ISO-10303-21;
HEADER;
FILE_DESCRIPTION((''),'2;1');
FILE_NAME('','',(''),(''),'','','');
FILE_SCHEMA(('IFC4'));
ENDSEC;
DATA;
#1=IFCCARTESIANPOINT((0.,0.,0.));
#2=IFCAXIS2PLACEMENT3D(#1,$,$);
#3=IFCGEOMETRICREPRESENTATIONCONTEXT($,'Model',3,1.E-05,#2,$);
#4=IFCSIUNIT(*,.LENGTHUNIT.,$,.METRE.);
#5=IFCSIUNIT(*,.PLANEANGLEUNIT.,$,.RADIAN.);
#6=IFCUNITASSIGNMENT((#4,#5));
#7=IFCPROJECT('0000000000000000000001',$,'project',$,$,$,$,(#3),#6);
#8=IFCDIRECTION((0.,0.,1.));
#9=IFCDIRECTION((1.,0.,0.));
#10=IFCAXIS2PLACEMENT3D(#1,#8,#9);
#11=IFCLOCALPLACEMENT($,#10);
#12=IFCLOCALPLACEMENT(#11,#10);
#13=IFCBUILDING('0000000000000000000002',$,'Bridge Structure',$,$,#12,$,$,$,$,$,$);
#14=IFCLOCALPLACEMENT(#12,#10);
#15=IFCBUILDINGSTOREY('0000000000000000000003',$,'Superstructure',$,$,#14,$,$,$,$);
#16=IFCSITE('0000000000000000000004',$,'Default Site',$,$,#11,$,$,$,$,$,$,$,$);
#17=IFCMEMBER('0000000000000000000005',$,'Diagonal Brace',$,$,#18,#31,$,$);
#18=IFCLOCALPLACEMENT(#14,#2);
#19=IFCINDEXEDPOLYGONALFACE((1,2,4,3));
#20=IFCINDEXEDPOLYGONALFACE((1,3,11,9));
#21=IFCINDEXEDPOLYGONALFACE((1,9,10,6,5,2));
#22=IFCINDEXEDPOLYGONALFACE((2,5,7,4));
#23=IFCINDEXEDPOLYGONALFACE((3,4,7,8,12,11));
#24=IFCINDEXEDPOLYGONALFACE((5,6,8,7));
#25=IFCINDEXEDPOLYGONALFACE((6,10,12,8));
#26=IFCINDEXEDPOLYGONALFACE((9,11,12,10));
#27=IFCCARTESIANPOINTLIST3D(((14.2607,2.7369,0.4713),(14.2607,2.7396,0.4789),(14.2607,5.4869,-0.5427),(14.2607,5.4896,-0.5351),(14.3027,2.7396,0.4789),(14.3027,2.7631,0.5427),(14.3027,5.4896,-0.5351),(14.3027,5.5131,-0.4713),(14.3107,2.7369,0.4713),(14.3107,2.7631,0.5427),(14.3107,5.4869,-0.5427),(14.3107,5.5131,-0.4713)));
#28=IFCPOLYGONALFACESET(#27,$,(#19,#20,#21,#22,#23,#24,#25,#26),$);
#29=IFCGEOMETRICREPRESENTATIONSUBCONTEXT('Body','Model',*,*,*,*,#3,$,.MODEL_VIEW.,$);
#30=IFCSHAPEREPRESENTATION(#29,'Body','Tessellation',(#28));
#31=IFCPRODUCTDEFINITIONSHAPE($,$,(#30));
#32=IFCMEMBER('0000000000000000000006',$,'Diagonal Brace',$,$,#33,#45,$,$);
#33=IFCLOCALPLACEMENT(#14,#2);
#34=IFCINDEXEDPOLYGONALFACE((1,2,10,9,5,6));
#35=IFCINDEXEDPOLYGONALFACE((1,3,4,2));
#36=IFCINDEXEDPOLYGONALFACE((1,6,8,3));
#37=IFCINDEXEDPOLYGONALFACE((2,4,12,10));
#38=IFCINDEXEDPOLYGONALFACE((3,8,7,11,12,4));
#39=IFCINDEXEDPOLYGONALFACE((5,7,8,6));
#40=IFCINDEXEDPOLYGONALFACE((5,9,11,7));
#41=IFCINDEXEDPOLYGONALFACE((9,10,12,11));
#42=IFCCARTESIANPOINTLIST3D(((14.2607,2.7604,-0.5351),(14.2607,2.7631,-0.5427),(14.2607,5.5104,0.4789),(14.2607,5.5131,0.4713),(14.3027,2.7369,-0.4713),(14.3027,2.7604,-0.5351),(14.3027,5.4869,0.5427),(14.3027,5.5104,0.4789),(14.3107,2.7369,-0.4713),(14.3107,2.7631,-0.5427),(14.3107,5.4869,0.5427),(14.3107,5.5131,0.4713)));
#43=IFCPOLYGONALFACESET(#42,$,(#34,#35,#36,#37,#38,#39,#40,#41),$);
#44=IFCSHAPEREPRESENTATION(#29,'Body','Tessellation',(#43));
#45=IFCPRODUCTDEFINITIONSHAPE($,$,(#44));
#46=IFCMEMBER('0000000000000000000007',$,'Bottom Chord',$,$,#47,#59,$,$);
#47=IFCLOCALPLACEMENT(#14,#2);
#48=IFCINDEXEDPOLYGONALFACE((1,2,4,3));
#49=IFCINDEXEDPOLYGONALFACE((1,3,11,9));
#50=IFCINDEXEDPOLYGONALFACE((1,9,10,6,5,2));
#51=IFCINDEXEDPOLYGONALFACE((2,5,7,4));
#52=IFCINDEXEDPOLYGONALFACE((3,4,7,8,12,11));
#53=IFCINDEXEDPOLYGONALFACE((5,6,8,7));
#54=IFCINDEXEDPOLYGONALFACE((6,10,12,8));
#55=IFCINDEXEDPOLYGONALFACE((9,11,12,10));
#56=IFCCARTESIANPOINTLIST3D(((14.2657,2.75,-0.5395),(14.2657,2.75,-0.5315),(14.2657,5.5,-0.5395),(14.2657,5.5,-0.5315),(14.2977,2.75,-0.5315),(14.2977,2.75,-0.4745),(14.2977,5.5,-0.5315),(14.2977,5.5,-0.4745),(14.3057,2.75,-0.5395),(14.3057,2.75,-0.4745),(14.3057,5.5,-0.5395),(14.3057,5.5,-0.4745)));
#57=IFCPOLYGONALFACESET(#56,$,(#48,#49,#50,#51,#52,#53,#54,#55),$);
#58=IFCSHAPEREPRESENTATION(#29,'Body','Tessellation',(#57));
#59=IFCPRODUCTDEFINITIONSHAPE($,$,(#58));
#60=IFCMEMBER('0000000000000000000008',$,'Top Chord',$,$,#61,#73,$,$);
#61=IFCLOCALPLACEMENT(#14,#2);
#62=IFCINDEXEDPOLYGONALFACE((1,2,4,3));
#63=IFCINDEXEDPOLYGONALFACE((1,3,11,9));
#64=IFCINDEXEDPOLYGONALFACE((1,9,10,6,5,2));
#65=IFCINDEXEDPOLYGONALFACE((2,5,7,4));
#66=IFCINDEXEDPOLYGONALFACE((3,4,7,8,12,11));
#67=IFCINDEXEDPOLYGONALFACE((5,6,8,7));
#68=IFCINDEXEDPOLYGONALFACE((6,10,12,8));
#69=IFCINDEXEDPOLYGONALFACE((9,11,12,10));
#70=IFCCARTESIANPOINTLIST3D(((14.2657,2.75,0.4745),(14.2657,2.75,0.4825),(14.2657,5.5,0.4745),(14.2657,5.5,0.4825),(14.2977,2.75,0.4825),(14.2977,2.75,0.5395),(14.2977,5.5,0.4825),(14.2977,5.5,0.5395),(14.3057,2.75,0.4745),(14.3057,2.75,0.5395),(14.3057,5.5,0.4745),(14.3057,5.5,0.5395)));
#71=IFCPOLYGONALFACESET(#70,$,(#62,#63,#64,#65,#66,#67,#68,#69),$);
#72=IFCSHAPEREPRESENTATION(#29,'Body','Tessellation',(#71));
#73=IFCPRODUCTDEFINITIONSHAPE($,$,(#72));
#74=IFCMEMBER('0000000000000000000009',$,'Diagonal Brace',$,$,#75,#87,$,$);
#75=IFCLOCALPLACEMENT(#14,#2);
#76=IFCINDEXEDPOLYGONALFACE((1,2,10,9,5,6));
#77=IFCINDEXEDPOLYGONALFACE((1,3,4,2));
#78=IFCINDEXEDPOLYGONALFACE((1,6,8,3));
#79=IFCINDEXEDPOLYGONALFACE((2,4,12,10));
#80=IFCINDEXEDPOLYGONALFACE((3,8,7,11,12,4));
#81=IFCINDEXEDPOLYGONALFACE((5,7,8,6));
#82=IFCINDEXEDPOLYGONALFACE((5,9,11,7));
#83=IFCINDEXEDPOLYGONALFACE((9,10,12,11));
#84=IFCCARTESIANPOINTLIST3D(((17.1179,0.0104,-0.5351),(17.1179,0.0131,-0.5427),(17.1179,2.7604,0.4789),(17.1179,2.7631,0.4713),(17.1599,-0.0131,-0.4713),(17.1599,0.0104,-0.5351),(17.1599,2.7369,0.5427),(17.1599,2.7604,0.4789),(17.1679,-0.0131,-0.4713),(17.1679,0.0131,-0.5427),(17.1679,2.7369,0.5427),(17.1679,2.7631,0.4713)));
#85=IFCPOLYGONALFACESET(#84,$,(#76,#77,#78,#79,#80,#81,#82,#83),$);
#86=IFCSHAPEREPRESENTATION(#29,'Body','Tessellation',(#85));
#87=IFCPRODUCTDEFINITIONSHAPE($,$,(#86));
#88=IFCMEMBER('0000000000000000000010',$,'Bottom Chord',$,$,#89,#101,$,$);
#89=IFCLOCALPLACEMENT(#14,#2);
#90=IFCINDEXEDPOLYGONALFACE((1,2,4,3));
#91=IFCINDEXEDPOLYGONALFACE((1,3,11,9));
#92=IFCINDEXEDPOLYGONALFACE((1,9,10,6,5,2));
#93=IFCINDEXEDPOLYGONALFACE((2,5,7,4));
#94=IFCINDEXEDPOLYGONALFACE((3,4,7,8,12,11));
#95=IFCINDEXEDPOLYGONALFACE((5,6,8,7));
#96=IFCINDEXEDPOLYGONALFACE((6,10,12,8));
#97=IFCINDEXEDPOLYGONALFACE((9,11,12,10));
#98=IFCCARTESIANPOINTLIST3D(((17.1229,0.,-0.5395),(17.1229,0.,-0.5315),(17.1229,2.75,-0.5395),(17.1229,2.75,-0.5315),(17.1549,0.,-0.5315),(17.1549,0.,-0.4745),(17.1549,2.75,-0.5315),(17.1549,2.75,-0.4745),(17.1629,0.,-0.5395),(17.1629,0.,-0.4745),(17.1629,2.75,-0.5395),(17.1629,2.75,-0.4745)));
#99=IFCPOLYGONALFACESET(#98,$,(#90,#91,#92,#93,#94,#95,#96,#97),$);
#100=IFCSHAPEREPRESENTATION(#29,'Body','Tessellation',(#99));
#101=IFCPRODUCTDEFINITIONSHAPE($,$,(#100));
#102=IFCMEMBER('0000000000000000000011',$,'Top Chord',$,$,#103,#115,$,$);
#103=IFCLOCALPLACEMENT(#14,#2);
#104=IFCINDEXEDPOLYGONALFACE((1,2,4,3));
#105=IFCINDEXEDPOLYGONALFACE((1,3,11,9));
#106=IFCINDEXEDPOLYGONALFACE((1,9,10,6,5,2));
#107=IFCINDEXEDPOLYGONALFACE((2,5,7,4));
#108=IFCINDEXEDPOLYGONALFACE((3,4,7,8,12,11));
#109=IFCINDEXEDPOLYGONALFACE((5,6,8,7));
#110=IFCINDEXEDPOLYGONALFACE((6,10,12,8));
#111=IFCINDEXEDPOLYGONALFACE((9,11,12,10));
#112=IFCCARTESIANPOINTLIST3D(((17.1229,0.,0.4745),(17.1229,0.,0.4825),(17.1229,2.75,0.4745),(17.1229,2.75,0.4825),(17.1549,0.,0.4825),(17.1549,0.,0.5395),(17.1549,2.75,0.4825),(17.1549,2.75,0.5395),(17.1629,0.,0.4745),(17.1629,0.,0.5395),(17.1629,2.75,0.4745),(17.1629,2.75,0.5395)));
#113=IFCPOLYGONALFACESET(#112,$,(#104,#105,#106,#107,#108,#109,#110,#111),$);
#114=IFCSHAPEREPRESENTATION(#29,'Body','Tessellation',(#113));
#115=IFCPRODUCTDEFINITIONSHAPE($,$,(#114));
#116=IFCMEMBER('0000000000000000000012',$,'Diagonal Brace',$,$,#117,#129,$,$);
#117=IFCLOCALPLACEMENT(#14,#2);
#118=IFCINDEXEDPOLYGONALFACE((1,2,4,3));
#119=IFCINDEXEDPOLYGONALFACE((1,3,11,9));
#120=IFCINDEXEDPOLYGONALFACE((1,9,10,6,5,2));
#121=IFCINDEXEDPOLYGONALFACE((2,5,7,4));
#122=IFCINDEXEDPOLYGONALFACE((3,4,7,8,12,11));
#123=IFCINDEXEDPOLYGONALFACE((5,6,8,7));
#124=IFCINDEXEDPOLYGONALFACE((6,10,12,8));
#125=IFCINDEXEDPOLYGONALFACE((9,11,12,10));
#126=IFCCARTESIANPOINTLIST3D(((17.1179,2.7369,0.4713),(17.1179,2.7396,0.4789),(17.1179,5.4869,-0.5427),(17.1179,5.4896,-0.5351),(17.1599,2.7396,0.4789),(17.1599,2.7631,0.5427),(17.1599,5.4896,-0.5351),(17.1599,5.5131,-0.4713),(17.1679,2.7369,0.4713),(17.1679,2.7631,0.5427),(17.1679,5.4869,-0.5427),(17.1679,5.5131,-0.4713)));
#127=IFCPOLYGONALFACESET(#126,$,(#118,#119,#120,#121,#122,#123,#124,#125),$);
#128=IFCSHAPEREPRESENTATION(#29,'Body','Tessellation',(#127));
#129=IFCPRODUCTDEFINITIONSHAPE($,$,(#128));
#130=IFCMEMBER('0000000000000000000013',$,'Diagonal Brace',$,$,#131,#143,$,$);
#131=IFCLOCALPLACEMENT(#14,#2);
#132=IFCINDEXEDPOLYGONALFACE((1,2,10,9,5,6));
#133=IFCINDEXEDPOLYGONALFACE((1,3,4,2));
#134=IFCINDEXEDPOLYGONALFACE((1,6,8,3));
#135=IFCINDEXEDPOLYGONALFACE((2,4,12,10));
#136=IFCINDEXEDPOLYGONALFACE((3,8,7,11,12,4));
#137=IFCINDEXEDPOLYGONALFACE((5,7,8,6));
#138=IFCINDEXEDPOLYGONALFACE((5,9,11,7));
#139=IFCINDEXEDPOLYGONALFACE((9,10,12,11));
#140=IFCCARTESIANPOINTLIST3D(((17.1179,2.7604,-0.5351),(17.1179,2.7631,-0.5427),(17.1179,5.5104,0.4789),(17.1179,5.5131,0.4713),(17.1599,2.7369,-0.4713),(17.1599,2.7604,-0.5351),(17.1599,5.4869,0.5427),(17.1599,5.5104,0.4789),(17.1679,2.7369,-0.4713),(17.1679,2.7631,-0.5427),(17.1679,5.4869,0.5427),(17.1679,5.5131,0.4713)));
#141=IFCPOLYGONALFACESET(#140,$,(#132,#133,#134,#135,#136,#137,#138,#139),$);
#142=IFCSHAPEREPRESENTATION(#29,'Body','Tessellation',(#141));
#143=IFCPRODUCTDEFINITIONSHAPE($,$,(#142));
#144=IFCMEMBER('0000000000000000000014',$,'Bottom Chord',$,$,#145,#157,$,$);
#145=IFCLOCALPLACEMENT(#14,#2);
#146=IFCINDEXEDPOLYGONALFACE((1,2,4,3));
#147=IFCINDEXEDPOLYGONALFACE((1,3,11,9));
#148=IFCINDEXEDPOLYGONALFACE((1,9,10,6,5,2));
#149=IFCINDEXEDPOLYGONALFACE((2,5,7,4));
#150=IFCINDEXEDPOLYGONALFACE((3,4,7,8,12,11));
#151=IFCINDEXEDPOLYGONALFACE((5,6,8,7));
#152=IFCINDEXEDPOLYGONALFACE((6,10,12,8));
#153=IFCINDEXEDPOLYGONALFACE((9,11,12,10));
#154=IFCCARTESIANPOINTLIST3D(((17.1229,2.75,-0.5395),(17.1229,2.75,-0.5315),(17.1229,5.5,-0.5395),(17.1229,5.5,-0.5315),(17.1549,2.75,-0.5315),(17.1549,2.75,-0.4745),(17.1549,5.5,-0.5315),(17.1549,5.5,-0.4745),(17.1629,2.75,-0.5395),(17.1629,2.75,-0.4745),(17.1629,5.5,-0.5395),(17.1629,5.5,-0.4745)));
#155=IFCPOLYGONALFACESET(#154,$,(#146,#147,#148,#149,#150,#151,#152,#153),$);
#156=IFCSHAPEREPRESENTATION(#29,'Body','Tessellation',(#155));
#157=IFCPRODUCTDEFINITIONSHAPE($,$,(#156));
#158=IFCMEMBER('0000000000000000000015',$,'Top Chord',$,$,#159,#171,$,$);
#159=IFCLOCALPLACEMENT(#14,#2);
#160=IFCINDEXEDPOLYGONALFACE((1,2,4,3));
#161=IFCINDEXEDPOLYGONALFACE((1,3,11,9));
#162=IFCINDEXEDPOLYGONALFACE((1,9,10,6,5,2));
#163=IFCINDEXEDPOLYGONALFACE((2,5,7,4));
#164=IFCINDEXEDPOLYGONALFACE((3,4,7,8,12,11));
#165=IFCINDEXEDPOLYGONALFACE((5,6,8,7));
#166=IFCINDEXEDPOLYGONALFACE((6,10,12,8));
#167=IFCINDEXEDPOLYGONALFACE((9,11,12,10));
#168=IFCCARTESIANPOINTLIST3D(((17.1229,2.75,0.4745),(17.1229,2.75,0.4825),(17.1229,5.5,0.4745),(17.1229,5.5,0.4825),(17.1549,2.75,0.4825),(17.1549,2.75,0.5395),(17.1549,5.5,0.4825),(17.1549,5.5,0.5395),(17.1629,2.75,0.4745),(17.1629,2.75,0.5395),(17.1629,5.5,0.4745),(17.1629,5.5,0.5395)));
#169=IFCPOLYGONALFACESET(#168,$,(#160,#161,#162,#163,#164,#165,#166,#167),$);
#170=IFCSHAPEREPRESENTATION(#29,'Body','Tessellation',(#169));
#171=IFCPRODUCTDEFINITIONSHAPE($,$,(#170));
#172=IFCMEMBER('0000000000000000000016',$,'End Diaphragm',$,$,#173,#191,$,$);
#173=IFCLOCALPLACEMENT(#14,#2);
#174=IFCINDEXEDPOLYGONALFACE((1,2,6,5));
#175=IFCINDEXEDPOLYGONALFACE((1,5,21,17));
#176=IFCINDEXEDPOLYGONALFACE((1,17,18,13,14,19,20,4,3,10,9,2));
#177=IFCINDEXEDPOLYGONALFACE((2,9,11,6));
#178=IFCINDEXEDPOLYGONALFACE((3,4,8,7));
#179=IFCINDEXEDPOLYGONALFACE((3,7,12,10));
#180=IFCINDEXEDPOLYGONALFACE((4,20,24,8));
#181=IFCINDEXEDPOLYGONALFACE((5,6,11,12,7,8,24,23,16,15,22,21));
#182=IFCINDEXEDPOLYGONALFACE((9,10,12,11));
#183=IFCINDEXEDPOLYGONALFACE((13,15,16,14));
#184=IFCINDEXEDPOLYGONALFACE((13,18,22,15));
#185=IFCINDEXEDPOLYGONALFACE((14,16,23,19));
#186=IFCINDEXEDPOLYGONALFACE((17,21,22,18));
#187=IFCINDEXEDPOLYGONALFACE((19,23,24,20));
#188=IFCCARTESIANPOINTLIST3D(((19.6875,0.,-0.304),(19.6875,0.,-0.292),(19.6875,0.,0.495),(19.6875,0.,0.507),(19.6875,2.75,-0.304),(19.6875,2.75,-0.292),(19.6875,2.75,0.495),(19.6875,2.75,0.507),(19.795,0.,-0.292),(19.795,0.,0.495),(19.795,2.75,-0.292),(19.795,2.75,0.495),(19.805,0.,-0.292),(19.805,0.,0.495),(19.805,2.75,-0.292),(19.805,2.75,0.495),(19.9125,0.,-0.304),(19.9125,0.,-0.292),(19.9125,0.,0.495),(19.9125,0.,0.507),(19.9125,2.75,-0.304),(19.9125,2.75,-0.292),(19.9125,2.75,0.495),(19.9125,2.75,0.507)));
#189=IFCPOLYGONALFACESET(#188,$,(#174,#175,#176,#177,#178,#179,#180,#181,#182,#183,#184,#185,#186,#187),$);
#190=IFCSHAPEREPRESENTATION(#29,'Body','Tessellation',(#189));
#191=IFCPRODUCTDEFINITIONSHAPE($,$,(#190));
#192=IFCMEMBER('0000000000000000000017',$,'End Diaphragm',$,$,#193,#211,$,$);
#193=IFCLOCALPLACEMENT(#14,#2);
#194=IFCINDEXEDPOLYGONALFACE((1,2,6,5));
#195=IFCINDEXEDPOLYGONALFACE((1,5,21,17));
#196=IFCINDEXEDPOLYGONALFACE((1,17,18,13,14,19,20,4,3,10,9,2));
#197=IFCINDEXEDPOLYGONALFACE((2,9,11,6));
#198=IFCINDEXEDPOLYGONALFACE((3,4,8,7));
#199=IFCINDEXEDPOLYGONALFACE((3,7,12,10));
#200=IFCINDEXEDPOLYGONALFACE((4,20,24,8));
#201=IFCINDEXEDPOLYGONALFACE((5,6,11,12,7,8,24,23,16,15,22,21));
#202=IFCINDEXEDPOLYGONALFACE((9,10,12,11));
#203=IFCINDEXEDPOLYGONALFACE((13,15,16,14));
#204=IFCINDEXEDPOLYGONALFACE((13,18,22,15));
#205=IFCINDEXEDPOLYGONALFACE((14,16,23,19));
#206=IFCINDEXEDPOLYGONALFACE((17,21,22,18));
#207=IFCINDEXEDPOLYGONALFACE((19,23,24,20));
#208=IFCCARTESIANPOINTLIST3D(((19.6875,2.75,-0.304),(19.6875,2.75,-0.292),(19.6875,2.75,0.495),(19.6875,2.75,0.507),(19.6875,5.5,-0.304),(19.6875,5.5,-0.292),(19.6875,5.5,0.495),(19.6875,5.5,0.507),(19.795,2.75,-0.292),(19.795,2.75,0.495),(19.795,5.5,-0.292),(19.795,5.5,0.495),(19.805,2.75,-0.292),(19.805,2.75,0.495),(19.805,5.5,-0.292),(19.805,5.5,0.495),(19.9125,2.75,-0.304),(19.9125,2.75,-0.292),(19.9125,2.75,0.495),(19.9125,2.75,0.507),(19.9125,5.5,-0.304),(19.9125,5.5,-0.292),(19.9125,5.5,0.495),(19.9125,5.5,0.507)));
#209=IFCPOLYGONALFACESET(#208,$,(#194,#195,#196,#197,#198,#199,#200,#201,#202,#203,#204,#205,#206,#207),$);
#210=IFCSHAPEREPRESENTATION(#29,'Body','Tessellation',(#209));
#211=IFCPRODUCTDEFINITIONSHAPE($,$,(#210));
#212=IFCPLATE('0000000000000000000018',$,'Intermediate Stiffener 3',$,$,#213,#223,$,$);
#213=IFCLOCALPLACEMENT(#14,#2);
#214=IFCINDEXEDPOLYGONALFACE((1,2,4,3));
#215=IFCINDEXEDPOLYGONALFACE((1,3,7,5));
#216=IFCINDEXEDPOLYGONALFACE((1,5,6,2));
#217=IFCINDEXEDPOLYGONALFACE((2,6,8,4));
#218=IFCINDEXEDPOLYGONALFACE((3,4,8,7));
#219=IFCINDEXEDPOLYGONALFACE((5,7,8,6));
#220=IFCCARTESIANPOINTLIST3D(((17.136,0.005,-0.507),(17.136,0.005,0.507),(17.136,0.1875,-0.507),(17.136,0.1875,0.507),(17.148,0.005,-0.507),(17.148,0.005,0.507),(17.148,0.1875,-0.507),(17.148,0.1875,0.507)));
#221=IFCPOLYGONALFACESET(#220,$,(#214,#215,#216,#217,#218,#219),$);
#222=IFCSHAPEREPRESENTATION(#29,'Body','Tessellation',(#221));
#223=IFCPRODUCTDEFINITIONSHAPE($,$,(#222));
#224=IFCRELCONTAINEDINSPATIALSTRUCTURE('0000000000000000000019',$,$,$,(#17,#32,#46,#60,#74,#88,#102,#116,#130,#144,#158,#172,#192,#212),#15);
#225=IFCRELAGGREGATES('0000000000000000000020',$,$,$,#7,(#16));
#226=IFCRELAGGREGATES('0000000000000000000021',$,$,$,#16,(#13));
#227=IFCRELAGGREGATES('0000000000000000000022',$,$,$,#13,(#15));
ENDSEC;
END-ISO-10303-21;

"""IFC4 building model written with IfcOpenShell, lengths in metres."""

from ifc_helpers import new_model, si_unit, frame, origin, origin_with_axes, origin_2d_with_axis, place, context, subcontext, project, spatial, rectangle, i_section, l_section, extrude, element, save


model = new_model("IFC4")

# Units and contexts
model_context = context("Model", 3, precision=1e-05, world=origin())
body_context = subcontext(model_context, "Body", "Model", "MODEL_VIEW")
ifc_project = project(units=[si_unit("LENGTHUNIT", "METRE"), si_unit("PLANEANGLEUNIT", "RADIAN")], contexts=[model_context])

# Site, building, storey
site_placement = place(None, origin_with_axes())
site = spatial("IfcSite", under=ifc_project, at=site_placement, Name="Default Site")
building_placement = place(site_placement, origin_with_axes())
building = spatial("IfcBuilding", under=site, at=building_placement, Name="Bridge Structure")
storey_placement = place(building_placement, origin_with_axes())
storey = spatial("IfcBuildingStorey", under=building, at=storey_placement, Name="Superstructure")

# Members
for number, where, z_axis, x_axis, name in (
    (1, (14.2857, 2.75, 0.507), (0.0, 0.93825, -0.345958), (-1.0, 0.0, 0.0), "Diagonal Brace"),
    (2, (14.2857, 2.75, -0.507), (0.0, 0.93825, 0.345958), (-1.0, 0.0, 0.0), "Diagonal Brace"),
):
    element("IfcMember", number, at=place(storey_placement, frame(where, z_axis=z_axis, x_axis=x_axis)), inside=storey, Name=name, context=body_context, shape_type="SweptSolid", body=[
        extrude(l_section(Depth=0.076, Width=0.05, Thickness=0.008, at=origin_2d_with_axis()), origin_with_axes(), (0.0, 0.0, 1.0), 2.931),
    ])
for number, where, z_axis, x_axis, name in (
    (3, (14.2857, 2.75, -0.507), (0.0, 1.0, 0.0), (-1.0, 0.0, 0.0), "Bottom Chord"),
    (4, (14.2857, 2.75, 0.507), (0.0, 1.0, 0.0), (-1.0, 0.0, 0.0), "Top Chord"),
):
    element("IfcMember", number, at=place(storey_placement, frame(where, z_axis=z_axis, x_axis=x_axis)), inside=storey, Name=name, context=body_context, shape_type="SweptSolid", body=[
        extrude(l_section(Depth=0.065, Width=0.04, Thickness=0.008, at=origin_2d_with_axis()), origin_with_axes(), (0.0, 0.0, 1.0), 2.75),
    ])
member_placement = place(storey_placement, frame((17.1429, 0.0, -0.507), z_axis=(0.0, 0.93825, 0.345958), x_axis=(-1.0, 0.0, 0.0)))
element("IfcMember", 5, at=member_placement, inside=storey, Name="Diagonal Brace", context=body_context, shape_type="SweptSolid", body=[
    extrude(l_section(Depth=0.076, Width=0.05, Thickness=0.008, at=origin_2d_with_axis()), origin_with_axes(), (0.0, 0.0, 1.0), 2.931),
])
for number, where, z_axis, x_axis, name in (
    (6, (17.1429, 0.0, -0.507), (0.0, 1.0, 0.0), (-1.0, 0.0, 0.0), "Bottom Chord"),
    (7, (17.1429, 0.0, 0.507), (0.0, 1.0, 0.0), (-1.0, 0.0, 0.0), "Top Chord"),
):
    element("IfcMember", number, at=place(storey_placement, frame(where, z_axis=z_axis, x_axis=x_axis)), inside=storey, Name=name, context=body_context, shape_type="SweptSolid", body=[
        extrude(l_section(Depth=0.065, Width=0.04, Thickness=0.008, at=origin_2d_with_axis()), origin_with_axes(), (0.0, 0.0, 1.0), 2.75),
    ])
for number, where, z_axis, x_axis, name in (
    (8, (17.1429, 2.75, 0.507), (0.0, 0.93825, -0.345958), (-1.0, 0.0, 0.0), "Diagonal Brace"),
    (9, (17.1429, 2.75, -0.507), (0.0, 0.93825, 0.345958), (-1.0, 0.0, 0.0), "Diagonal Brace"),
):
    element("IfcMember", number, at=place(storey_placement, frame(where, z_axis=z_axis, x_axis=x_axis)), inside=storey, Name=name, context=body_context, shape_type="SweptSolid", body=[
        extrude(l_section(Depth=0.076, Width=0.05, Thickness=0.008, at=origin_2d_with_axis()), origin_with_axes(), (0.0, 0.0, 1.0), 2.931),
    ])
for number, where, z_axis, x_axis, name in (
    (10, (17.1429, 2.75, -0.507), (0.0, 1.0, 0.0), (-1.0, 0.0, 0.0), "Bottom Chord"),
    (11, (17.1429, 2.75, 0.507), (0.0, 1.0, 0.0), (-1.0, 0.0, 0.0), "Top Chord"),
):
    element("IfcMember", number, at=place(storey_placement, frame(where, z_axis=z_axis, x_axis=x_axis)), inside=storey, Name=name, context=body_context, shape_type="SweptSolid", body=[
        extrude(l_section(Depth=0.065, Width=0.04, Thickness=0.008, at=origin_2d_with_axis()), origin_with_axes(), (0.0, 0.0, 1.0), 2.75),
    ])
for number, where, z_axis, x_axis, name in (
    (12, (19.8, 0.0, 0.1015), (0.0, 1.0, 0.0), (-1.0, 0.0, 0.0), "End Diaphragm"),
    (13, (19.8, 2.75, 0.1015), (0.0, 1.0, 0.0), (-1.0, 0.0, 0.0), "End Diaphragm"),
):
    element("IfcMember", number, at=place(storey_placement, frame(where, z_axis=z_axis, x_axis=x_axis)), inside=storey, Name=name, context=body_context, shape_type="SweptSolid", body=[
        extrude(i_section(OverallWidth=0.225, OverallDepth=0.811, WebThickness=0.01, FlangeThickness=0.012, at=origin_2d_with_axis()), origin_with_axes(), (0.0, 0.0, 1.0), 2.75),
    ])

# Plate
plate_placement = place(storey_placement, frame((17.142, 0.0963, -0.507), z_axis=(0.0, 0.0, 1.0), x_axis=(1.0, 0.0, 0.0)))
element("IfcPlate", 14, at=plate_placement, inside=storey, Name="Intermediate Stiffener 3", context=body_context, shape_type="SweptSolid", body=[
    extrude(rectangle(XDim=0.012, YDim=0.1825, at=origin_2d_with_axis()), origin_with_axes(), (0.0, 0.0, 1.0), 1.014),
])

save(model, "model.ifc")
